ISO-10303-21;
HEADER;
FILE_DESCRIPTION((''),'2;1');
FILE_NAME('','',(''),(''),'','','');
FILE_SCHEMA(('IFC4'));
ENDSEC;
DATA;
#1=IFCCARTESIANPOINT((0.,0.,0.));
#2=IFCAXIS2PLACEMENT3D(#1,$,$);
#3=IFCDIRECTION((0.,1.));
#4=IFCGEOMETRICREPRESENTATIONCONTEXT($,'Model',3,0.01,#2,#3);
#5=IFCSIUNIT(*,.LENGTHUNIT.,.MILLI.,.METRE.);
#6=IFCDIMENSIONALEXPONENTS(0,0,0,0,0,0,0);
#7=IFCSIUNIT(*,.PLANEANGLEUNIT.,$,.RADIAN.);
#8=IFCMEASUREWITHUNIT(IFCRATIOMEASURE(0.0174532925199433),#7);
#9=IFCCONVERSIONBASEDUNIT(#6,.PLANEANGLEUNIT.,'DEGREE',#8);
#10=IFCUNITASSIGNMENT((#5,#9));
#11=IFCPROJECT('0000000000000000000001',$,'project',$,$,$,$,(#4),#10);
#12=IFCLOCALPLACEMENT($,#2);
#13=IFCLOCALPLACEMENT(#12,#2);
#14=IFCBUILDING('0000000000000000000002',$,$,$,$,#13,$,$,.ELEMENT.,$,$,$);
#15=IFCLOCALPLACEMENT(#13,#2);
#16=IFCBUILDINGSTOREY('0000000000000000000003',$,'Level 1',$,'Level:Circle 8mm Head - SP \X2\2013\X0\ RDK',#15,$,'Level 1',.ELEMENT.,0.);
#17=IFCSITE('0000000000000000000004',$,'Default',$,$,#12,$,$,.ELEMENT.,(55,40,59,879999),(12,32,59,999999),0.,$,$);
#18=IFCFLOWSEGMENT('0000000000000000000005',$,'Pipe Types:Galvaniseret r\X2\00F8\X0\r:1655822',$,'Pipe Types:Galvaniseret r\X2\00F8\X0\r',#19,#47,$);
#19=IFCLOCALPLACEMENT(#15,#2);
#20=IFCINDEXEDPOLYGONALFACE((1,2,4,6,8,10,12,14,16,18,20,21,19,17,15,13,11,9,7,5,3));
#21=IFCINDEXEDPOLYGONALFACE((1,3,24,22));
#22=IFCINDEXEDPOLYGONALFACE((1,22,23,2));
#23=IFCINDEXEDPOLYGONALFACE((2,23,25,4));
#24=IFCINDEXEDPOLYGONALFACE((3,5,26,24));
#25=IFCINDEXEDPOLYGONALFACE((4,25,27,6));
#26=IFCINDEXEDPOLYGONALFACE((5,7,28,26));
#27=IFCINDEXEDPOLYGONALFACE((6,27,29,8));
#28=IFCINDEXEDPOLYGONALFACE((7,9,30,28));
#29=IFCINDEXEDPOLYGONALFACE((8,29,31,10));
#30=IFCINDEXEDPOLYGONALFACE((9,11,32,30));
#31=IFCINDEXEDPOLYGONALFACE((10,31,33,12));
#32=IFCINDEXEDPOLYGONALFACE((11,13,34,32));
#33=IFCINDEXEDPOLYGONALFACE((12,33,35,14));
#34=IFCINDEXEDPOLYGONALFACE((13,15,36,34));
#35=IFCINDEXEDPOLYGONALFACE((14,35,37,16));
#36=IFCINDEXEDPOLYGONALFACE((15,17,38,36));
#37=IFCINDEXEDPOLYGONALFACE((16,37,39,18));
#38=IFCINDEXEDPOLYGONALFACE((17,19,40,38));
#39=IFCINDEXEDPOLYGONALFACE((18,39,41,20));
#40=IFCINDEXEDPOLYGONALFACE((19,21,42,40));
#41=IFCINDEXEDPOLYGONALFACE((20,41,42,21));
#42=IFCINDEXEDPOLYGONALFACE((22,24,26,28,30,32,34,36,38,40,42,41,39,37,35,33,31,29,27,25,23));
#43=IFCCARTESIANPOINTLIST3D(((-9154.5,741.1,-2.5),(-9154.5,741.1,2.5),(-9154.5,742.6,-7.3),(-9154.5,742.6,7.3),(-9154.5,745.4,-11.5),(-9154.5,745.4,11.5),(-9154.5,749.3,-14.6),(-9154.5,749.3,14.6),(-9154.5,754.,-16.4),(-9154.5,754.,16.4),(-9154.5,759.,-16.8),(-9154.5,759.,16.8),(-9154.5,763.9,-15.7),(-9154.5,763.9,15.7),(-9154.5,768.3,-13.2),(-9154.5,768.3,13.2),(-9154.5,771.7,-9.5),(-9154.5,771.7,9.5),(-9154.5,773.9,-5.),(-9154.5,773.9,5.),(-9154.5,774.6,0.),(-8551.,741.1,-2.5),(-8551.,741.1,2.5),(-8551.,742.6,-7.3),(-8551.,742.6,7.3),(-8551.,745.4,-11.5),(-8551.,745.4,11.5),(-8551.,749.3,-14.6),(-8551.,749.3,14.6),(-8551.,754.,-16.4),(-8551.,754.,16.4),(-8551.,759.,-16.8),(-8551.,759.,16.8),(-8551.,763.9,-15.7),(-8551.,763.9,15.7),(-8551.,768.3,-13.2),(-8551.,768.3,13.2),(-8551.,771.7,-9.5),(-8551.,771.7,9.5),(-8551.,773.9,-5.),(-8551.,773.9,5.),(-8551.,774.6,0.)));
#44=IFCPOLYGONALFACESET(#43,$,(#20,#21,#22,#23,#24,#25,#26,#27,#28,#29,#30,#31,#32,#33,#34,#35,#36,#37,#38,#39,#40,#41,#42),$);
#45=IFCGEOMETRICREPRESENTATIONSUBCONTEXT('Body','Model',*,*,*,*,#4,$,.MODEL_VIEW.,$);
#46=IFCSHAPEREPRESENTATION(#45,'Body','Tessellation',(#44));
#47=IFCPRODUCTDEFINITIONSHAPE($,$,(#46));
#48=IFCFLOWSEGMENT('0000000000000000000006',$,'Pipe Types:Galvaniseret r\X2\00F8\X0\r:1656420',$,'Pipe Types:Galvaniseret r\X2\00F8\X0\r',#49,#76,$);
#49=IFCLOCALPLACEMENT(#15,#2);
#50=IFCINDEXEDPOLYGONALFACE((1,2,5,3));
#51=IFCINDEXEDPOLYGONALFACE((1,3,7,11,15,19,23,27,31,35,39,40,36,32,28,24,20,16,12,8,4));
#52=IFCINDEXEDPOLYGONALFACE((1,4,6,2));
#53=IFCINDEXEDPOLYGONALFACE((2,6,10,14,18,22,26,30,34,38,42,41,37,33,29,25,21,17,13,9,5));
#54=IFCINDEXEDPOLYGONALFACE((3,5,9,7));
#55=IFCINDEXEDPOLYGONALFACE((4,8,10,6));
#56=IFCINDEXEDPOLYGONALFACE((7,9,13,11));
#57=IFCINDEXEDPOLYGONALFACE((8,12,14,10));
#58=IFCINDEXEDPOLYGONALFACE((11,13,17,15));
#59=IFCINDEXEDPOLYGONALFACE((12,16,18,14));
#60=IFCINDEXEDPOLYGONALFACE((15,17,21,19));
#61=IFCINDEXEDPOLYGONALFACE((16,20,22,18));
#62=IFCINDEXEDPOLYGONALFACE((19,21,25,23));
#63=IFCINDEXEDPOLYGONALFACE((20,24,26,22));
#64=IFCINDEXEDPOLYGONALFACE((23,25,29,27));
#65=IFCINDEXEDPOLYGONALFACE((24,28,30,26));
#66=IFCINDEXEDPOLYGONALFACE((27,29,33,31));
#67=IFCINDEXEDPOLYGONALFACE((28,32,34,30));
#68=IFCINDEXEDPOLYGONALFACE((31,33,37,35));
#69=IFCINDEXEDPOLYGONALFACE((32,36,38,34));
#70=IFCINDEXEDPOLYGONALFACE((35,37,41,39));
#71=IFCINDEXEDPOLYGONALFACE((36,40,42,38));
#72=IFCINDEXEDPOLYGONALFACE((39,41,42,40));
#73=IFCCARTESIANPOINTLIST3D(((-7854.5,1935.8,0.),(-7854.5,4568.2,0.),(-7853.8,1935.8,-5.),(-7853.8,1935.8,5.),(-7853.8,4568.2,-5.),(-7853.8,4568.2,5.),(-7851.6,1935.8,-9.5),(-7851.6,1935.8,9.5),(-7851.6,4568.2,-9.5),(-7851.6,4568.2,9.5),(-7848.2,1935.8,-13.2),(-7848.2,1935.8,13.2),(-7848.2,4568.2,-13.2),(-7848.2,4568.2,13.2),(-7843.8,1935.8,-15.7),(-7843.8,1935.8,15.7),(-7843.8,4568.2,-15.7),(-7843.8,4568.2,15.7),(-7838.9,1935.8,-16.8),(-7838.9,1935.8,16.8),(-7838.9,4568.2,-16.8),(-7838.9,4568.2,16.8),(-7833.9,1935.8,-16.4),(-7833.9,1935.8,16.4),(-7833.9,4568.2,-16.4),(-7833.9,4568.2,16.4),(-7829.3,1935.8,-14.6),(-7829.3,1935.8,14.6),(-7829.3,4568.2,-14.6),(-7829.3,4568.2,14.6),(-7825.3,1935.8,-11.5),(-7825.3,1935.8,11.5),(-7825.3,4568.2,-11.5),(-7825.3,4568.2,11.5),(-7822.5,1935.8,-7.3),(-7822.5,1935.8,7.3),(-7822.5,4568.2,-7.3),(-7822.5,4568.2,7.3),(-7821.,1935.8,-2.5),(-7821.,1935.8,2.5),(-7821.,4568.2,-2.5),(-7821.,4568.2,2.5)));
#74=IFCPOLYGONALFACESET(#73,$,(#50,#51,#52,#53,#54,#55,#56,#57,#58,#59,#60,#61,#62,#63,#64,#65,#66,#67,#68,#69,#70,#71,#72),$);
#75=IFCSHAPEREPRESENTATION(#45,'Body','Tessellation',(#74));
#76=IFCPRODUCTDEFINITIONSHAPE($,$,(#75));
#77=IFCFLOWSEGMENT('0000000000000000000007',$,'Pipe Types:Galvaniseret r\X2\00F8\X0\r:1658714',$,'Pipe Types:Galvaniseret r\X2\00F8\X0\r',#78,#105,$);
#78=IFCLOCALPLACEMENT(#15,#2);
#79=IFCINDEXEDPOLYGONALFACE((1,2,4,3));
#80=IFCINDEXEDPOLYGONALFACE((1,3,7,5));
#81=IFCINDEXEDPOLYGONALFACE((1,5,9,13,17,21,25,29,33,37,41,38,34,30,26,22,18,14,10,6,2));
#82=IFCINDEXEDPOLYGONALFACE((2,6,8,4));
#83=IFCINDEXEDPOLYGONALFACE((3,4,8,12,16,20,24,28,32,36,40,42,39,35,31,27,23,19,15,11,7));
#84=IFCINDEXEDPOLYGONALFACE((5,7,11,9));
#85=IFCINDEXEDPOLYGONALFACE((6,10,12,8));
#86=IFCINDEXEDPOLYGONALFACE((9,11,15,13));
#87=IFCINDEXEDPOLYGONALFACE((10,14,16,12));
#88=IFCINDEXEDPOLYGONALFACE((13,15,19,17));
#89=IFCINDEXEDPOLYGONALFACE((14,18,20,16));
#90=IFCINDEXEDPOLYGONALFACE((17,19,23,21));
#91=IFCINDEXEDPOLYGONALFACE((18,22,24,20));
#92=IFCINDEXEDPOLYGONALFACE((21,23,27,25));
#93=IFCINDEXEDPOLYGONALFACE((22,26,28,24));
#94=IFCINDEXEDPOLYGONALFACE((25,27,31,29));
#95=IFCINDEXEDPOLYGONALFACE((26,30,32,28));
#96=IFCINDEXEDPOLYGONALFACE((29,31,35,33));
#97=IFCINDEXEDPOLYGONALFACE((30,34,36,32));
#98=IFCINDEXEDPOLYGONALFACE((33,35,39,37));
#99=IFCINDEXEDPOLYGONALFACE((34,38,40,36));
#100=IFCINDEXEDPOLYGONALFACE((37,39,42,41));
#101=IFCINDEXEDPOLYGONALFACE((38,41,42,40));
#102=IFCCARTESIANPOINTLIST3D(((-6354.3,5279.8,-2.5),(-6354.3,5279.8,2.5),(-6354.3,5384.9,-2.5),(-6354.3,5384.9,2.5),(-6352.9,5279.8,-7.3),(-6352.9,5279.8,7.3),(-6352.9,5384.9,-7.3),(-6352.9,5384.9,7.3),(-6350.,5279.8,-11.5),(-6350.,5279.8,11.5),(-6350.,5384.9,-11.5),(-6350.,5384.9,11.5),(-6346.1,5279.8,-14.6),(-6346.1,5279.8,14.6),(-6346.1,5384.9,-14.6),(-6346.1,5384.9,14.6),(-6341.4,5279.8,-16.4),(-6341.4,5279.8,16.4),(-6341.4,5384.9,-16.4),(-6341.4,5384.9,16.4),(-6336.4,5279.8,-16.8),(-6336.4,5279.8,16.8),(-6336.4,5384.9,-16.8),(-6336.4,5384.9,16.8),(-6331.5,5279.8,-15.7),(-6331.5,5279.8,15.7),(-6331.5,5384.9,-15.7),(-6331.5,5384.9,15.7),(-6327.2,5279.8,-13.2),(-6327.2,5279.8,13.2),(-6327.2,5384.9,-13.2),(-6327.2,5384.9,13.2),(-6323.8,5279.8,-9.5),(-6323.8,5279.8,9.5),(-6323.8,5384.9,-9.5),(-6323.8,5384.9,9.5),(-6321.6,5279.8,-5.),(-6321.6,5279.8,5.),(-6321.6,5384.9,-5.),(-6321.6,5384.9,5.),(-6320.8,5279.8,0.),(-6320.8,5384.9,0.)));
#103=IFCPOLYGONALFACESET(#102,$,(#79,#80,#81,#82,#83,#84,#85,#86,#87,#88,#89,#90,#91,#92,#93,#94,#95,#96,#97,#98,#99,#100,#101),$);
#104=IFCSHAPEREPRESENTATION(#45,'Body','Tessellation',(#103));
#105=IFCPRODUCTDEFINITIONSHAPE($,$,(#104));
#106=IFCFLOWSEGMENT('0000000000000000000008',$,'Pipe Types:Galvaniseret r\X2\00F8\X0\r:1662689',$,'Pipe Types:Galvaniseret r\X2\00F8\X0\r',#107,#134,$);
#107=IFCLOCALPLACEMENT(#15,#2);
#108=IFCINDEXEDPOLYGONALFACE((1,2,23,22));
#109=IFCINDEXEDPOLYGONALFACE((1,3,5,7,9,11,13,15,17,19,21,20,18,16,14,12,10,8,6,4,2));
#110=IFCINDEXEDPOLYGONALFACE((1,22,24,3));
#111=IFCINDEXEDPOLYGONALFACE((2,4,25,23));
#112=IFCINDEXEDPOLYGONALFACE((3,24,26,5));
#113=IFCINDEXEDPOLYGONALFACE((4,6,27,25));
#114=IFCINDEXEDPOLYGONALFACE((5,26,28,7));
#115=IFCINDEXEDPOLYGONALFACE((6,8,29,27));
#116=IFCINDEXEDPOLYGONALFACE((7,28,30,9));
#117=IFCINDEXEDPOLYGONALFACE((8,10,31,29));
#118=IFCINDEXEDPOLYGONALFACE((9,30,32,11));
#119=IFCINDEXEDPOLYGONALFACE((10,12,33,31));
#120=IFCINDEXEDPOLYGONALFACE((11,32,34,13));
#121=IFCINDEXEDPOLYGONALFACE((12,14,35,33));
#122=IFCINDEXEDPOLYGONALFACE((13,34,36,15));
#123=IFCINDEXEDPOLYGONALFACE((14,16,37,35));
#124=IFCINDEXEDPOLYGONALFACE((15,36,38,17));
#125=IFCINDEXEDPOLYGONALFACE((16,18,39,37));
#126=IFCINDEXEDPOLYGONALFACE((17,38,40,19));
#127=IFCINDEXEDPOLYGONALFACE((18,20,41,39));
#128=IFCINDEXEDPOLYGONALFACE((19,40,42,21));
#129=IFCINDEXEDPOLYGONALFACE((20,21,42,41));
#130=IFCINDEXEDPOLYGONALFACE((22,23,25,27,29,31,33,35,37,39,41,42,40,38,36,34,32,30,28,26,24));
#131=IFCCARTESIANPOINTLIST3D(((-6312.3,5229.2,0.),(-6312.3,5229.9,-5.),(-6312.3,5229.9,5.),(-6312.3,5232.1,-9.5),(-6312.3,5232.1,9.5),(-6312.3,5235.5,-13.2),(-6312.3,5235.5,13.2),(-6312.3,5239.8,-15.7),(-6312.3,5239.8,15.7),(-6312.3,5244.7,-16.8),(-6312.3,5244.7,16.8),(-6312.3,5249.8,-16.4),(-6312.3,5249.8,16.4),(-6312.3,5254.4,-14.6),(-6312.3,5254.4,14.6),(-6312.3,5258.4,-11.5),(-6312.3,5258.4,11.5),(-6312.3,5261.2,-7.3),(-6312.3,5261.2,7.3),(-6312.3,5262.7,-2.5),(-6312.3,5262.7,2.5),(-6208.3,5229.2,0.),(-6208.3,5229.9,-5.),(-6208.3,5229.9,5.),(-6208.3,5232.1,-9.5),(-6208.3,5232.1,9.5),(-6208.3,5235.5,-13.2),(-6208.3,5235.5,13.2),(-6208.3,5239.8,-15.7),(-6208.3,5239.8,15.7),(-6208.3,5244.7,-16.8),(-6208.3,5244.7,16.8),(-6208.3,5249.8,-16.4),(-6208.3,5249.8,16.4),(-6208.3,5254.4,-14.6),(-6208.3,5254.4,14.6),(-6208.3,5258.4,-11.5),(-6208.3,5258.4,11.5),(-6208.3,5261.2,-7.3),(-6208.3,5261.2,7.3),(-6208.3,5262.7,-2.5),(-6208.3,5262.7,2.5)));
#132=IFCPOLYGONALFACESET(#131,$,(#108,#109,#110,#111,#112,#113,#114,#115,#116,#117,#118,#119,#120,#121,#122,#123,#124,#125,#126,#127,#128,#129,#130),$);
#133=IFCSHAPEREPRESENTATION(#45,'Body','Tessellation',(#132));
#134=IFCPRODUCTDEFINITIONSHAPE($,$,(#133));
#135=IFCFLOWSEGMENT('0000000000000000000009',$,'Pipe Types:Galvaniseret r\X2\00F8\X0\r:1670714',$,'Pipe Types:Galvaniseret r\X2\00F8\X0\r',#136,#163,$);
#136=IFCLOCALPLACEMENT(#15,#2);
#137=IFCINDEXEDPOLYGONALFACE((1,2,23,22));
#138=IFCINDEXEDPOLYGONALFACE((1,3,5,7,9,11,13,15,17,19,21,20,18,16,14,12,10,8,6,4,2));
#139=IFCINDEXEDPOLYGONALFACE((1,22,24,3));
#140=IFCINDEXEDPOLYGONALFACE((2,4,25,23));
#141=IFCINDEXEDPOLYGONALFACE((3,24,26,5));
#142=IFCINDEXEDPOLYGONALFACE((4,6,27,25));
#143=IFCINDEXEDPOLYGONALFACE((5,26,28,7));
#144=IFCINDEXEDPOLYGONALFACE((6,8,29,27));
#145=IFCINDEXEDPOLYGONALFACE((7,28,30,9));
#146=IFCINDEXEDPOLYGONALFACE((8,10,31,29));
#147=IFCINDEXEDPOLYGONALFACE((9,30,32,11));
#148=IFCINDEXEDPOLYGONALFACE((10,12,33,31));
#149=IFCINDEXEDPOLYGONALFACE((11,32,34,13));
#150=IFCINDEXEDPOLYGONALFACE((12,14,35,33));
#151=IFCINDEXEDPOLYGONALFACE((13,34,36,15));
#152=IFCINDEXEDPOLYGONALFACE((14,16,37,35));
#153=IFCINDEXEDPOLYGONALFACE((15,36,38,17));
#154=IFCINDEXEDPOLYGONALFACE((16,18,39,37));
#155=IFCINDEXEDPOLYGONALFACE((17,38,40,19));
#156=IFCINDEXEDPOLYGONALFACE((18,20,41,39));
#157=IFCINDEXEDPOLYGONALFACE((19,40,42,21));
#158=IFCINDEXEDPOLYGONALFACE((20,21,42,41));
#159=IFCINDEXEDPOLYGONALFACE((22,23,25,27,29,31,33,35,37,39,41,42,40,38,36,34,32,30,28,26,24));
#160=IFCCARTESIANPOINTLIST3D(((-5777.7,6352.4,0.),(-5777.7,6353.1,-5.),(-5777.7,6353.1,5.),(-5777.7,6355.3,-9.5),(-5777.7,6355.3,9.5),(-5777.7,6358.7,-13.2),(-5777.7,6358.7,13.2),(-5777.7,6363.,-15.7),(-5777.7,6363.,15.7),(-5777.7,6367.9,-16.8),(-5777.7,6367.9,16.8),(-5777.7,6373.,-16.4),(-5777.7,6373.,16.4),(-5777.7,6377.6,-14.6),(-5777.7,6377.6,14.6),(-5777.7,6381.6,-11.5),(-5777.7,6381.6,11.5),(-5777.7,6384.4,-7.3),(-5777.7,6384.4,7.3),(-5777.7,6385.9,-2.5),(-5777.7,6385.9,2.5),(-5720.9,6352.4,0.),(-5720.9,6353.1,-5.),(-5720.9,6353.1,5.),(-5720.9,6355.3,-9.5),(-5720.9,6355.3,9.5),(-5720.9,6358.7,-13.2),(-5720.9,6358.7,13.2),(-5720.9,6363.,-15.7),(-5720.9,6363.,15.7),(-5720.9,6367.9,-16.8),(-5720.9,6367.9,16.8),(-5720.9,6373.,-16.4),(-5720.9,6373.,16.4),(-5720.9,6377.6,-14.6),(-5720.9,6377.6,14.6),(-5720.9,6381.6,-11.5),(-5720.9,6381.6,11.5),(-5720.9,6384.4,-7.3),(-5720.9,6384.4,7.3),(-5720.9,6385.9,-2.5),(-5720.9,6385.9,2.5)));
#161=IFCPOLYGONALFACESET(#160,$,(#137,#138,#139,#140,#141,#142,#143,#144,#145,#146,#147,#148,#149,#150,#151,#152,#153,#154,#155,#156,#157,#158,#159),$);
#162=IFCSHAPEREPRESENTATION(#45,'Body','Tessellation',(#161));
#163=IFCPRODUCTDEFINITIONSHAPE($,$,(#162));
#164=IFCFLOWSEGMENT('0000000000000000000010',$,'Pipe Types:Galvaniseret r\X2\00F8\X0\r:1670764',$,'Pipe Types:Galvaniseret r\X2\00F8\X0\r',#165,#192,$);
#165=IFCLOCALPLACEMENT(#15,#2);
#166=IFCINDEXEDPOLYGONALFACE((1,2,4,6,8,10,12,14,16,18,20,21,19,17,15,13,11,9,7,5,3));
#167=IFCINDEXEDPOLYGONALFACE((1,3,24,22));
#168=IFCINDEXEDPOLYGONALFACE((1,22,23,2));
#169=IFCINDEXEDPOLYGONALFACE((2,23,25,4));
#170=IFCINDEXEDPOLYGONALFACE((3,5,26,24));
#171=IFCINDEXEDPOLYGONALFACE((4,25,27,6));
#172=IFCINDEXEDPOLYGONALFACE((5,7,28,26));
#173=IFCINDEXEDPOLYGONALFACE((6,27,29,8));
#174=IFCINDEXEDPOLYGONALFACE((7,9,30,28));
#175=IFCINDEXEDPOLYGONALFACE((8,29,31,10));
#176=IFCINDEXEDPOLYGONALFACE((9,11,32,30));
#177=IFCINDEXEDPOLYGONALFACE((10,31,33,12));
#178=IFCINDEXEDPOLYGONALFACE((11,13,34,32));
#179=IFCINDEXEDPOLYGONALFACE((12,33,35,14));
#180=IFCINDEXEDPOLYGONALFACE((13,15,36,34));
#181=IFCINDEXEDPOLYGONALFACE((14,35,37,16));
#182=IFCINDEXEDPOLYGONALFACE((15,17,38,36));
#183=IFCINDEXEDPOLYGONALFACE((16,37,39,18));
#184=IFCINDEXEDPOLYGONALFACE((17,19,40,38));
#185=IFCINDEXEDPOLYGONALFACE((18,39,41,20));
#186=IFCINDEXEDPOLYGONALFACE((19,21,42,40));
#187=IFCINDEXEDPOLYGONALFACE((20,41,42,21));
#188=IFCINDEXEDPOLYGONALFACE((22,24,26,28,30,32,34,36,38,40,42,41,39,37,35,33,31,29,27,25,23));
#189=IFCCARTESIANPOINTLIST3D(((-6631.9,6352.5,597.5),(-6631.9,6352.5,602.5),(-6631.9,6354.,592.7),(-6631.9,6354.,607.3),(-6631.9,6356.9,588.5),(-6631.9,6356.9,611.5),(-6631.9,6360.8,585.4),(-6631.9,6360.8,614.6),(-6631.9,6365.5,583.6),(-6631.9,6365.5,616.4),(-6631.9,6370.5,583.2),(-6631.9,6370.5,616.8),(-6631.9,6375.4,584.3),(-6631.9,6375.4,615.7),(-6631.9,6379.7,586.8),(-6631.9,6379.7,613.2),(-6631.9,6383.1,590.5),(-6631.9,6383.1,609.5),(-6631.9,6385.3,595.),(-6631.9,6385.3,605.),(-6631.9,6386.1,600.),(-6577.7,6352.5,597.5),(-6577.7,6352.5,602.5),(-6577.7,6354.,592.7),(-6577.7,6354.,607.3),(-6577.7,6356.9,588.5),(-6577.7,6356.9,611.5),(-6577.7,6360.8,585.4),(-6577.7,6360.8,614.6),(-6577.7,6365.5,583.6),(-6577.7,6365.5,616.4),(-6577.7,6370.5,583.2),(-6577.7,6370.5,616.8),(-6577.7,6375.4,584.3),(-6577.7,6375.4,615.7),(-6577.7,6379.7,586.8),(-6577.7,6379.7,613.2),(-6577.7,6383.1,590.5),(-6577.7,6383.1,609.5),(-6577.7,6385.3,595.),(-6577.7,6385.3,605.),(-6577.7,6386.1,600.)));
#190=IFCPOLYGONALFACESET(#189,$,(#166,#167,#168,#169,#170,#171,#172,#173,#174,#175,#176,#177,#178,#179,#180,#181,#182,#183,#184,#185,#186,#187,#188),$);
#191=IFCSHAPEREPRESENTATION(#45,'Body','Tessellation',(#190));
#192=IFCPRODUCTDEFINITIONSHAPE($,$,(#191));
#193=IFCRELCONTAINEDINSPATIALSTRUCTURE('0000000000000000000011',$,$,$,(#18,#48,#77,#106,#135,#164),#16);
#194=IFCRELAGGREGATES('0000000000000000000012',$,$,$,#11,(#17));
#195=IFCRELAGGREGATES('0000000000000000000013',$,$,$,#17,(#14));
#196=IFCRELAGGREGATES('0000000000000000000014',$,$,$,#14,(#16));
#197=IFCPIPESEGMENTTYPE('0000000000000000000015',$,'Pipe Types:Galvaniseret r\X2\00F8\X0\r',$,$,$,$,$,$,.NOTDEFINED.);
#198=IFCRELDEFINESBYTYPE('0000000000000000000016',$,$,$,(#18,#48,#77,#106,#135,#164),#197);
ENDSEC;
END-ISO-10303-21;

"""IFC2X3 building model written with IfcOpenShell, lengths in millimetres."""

from ifc_helpers import new_model, entity, si_unit, converted_unit, direction, frame, frame_2d, origin, origin_2d_with_axis, place, context, subcontext, project, spatial, circle, extrude, type_object, element, save


model = new_model("IFC2X3")

# Units and contexts
model_context = context("Model", 3, precision=0.01, world=origin(), true_north=direction((0.0, 1.0)))
body_context = subcontext(model_context, "Body", "Model", "MODEL_VIEW")
ifc_project = project(units=[si_unit("LENGTHUNIT", "METRE", prefix="MILLI"), converted_unit("PLANEANGLEUNIT", "DEGREE", entity("IfcRatioMeasure", 0.0174532925199433), si_unit("PLANEANGLEUNIT", "RADIAN"), dimensions=[0, 0, 0, 0, 0, 0, 0])], contexts=[model_context])

# Site, building, storey
site_placement = place(None, origin())
site = spatial("IfcSite", under=ifc_project, at=site_placement, Name="Default", CompositionType="ELEMENT", RefLatitude=(55, 40, 59, 879999), RefLongitude=(12, 32, 59, 999999), RefElevation=0.0)
building_placement = place(site_placement, origin())
building = spatial("IfcBuilding", under=site, at=building_placement, CompositionType="ELEMENT")
storey_placement = place(building_placement, origin())
storey = spatial("IfcBuildingStorey", under=building, at=storey_placement, Name="Level 1", ObjectType="Level:Circle 8mm Head - SP – RDK", LongName="Level 1", CompositionType="ELEMENT", Elevation=0.0)

# Flow segments
pipe_segment_type = type_object("IfcPipeSegmentType", Name="Pipe Types:Galvaniseret rør", PredefinedType="NOTDEFINED")
flow_segment_1_placement = place(storey_placement, origin())
element("IfcFlowSegment", 1, at=flow_segment_1_placement, inside=storey, type_object=pipe_segment_type, Name="Pipe Types:Galvaniseret rør:1655822", ObjectType="Pipe Types:Galvaniseret rør", context=body_context, shape_type="SweptSolid", body=[
    extrude(circle(Radius=16.9, at=frame_2d((0.0, 0.0), x_axis=(1.0, 0.0))), frame((-9154.5, 757.8, 0.0), z_axis=(1.0, 0.0, 0.0), x_axis=(0.0, 1.0, 0.0)), (0.0, 0.0, 1.0), 603.5),
])
flow_segment_2_placement = place(storey_placement, origin())
element("IfcFlowSegment", 2, at=flow_segment_2_placement, inside=storey, type_object=pipe_segment_type, Name="Pipe Types:Galvaniseret rør:1656420", ObjectType="Pipe Types:Galvaniseret rør", context=body_context, shape_type="SweptSolid", body=[
    extrude(circle(Radius=16.9, at=frame_2d((0.0, 0.0), x_axis=(1.0, 0.0))), frame((-7837.7, 1935.8, 0.0), z_axis=(0.0, 1.0, 0.0), x_axis=(-1.0, 0.0, 0.0)), (0.0, 0.0, 1.0), 2632.4),
])
flow_segment_3_placement = place(storey_placement, origin())
element("IfcFlowSegment", 3, at=flow_segment_3_placement, inside=storey, type_object=pipe_segment_type, Name="Pipe Types:Galvaniseret rør:1658714", ObjectType="Pipe Types:Galvaniseret rør", context=body_context, shape_type="SweptSolid", body=[
    extrude(circle(Radius=16.9, at=frame_2d((0.0, 0.0), x_axis=(1.0, 0.0))), frame((-6337.7, 5279.8, 0.0), z_axis=(0.0, 1.0, 0.0), x_axis=(1.0, 0.0, 0.0)), (0.0, 0.0, 1.0), 105.1),
])
flow_segment_4_placement = place(storey_placement, origin())
element("IfcFlowSegment", 4, at=flow_segment_4_placement, inside=storey, type_object=pipe_segment_type, Name="Pipe Types:Galvaniseret rør:1662689", ObjectType="Pipe Types:Galvaniseret rør", context=body_context, shape_type="SweptSolid", body=[
    extrude(circle(Radius=16.9, at=frame_2d((0.0, 0.0), x_axis=(1.0, 0.0))), frame((-6312.3, 5246.0, 0.0), z_axis=(1.0, 0.0, 0.0), x_axis=(0.0, -1.0, 0.0)), (0.0, 0.0, 1.0), 104.1),
])
flow_segment_5_placement = place(storey_placement, origin())
element("IfcFlowSegment", 5, at=flow_segment_5_placement, inside=storey, type_object=pipe_segment_type, Name="Pipe Types:Galvaniseret rør:1670714", ObjectType="Pipe Types:Galvaniseret rør", context=body_context, shape_type="SweptSolid", body=[
    extrude(circle(Radius=16.9, at=frame_2d((0.0, 0.0), x_axis=(1.0, 0.0))), frame((-5777.7, 6369.2, 0.0), z_axis=(1.0, 0.0, 0.0), x_axis=(0.0, -1.0, 0.0)), (0.0, 0.0, 1.0), 56.8),
])
flow_segment_6_placement = place(storey_placement, origin())
element("IfcFlowSegment", 6, at=flow_segment_6_placement, inside=storey, type_object=pipe_segment_type, Name="Pipe Types:Galvaniseret rør:1670764", ObjectType="Pipe Types:Galvaniseret rør", context=body_context, shape_type="SweptSolid", body=[
    extrude(circle(Radius=16.9, at=origin_2d_with_axis()), frame((-6631.9, 6369.2, 600.0), z_axis=(1.0, 0.0, 0.0), x_axis=(0.0, 1.0, 0.0)), (0.0, 0.0, 1.0), 54.2),
])

save(model, "model.ifc")
